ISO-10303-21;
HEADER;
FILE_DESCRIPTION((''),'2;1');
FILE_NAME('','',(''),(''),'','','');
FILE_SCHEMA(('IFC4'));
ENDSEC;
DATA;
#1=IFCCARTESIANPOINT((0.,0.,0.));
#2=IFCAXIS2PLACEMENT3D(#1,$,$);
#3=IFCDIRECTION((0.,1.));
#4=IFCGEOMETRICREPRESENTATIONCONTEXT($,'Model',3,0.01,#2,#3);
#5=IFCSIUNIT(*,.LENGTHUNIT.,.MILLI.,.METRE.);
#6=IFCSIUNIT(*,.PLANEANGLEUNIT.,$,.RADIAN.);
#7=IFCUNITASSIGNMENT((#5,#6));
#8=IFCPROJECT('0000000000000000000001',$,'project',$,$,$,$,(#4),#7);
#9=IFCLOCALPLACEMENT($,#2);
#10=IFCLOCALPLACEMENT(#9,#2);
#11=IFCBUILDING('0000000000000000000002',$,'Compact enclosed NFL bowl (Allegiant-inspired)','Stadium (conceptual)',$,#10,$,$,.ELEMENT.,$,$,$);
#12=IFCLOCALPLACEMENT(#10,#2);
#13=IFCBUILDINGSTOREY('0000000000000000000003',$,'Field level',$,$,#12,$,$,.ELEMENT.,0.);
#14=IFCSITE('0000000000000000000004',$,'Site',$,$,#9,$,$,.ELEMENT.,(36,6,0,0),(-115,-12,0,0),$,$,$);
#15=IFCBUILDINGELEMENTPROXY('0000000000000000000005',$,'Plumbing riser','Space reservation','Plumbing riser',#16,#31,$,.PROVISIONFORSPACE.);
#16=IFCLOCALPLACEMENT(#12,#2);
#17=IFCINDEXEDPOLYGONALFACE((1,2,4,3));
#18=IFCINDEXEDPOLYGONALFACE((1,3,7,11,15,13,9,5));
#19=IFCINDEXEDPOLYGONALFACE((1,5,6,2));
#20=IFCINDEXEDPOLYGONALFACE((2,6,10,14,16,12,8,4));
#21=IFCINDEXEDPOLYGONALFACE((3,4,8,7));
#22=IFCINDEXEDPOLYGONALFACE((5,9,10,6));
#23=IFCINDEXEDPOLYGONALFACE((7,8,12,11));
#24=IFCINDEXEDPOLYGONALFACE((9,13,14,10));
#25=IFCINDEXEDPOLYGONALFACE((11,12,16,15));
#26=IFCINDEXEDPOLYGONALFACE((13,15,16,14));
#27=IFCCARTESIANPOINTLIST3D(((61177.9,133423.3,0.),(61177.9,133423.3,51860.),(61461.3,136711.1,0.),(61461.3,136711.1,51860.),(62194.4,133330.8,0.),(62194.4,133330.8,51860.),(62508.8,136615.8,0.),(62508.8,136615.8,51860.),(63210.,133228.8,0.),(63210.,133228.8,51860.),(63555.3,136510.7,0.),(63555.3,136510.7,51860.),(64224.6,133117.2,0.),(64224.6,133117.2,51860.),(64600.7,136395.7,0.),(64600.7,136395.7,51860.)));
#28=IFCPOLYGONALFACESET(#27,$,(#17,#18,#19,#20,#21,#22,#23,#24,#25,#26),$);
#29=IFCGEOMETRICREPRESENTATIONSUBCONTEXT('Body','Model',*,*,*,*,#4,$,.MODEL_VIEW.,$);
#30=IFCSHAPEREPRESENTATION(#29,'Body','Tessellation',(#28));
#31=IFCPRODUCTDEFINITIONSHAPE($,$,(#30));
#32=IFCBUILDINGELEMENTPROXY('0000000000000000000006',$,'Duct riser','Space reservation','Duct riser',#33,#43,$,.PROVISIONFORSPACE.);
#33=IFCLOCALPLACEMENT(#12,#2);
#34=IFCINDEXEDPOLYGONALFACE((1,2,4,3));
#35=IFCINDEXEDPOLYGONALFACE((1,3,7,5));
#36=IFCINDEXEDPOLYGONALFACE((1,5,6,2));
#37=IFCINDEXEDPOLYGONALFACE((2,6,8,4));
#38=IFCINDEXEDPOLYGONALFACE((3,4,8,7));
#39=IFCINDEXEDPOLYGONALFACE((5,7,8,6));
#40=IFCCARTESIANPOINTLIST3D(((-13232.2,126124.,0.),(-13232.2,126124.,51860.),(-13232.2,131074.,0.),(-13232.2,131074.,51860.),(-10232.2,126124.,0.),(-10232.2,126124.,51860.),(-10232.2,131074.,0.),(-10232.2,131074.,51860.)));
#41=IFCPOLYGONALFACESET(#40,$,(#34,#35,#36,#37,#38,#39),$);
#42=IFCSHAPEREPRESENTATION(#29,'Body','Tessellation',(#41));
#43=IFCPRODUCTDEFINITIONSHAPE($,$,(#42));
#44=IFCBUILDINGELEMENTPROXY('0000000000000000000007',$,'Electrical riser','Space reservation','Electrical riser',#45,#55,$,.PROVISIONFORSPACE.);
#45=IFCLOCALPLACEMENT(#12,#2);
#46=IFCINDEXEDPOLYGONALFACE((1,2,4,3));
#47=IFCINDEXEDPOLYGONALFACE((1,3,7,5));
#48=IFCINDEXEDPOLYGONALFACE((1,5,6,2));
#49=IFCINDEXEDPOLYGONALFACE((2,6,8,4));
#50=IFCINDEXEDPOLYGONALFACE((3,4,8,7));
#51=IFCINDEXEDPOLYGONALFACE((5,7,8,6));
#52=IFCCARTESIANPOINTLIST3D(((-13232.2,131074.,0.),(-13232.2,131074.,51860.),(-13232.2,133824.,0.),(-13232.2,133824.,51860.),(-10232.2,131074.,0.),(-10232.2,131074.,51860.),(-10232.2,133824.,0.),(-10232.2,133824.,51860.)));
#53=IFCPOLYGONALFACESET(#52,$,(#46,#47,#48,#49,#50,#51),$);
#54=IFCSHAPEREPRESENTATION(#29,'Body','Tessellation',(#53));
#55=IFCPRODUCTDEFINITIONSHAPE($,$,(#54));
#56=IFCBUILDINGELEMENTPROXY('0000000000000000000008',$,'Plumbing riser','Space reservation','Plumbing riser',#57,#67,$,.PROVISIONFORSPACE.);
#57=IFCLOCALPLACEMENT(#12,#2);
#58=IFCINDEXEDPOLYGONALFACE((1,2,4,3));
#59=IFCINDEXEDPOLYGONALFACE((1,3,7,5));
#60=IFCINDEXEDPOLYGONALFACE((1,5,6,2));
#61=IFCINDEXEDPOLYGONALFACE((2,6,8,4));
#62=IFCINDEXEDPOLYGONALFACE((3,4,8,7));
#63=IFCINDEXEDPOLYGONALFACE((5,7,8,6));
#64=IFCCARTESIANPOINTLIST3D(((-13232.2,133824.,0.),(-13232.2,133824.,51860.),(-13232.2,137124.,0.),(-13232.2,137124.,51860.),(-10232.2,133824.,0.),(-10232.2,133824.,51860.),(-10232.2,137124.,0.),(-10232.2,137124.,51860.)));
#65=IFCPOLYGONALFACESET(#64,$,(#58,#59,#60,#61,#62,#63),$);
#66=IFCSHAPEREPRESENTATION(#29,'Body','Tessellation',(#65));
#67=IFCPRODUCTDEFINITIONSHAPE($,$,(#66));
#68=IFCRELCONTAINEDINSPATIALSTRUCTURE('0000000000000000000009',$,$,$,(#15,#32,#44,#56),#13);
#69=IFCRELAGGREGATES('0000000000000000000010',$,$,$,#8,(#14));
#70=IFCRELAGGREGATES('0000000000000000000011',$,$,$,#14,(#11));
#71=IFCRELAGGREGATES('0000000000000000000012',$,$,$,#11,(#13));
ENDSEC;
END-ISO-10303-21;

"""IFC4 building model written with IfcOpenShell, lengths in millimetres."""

from ifc_helpers import new_model, si_unit, direction, origin, place, context, subcontext, project, spatial, line, arc, indexed_curve, outline, extrude, element, save


model = new_model("IFC4")

# Units and contexts
model_context = context("Model", 3, precision=0.01, world=origin(), true_north=direction((0.0, 1.0)))
body_context = subcontext(model_context, "Body", "Model", "MODEL_VIEW")
ifc_project = project(units=[si_unit("LENGTHUNIT", "METRE", prefix="MILLI"), si_unit("PLANEANGLEUNIT", "RADIAN")], contexts=[model_context])

# Site, building, storey
site_placement = place(None, origin())
site = spatial("IfcSite", under=ifc_project, at=site_placement, Name="Site", CompositionType="ELEMENT", RefLatitude=(36, 6, 0, 0), RefLongitude=(-115, -12, 0, 0))
building_placement = place(site_placement, origin())
building = spatial("IfcBuilding", under=site, at=building_placement, Name="Compact enclosed NFL bowl (Allegiant-inspired)", Description="Stadium (conceptual)", CompositionType="ELEMENT")
storey_placement = place(building_placement, origin())
storey = spatial("IfcBuildingStorey", under=building, at=storey_placement, Name="Field level", CompositionType="ELEMENT", Elevation=0.0)

# Shared definitions
placement_1 = place(storey_placement, origin())

# Building element proxies
element("IfcBuildingElementProxy", 1, at=placement_1, inside=storey, Name="Plumbing riser", Description="Space reservation", ObjectType="Plumbing riser", PredefinedType="PROVISIONFORSPACE", context=body_context, shape_type="SweptSolid", body=[
    extrude(outline(indexed_curve([(64224.6, 133117.2), (62702.3, 133281.0), (61177.9, 133423.3), (61461.3, 136711.1), (63032.1, 136564.5), (64600.7, 136395.7)], segments=[arc(1, 2, 3), line(3, 4), arc(4, 5, 6), line(6, 1)], self_intersect=False)), origin(), (0.0, 0.0, 1.0), 51860.0),
])
element("IfcBuildingElementProxy", 2, at=placement_1, inside=storey, Name="Duct riser", Description="Space reservation", ObjectType="Duct riser", PredefinedType="PROVISIONFORSPACE", context=body_context, shape_type="SweptSolid", body=[
    extrude(outline(indexed_curve([(-10232.2, 126124.0), (-13232.2, 126124.0), (-13232.2, 131074.0), (-10232.2, 131074.0)], segments=[line(1, 2), line(2, 3), line(3, 4), line(4, 1)], self_intersect=False)), origin(), (0.0, 0.0, 1.0), 51860.0),
])
element("IfcBuildingElementProxy", 3, at=placement_1, inside=storey, Name="Electrical riser", Description="Space reservation", ObjectType="Electrical riser", PredefinedType="PROVISIONFORSPACE", context=body_context, shape_type="SweptSolid", body=[
    extrude(outline(indexed_curve([(-10232.2, 131074.0), (-13232.2, 131074.0), (-13232.2, 133824.0), (-10232.2, 133824.0)], segments=[line(1, 2), line(2, 3), line(3, 4), line(4, 1)], self_intersect=False)), origin(), (0.0, 0.0, 1.0), 51860.0),
])
element("IfcBuildingElementProxy", 4, at=placement_1, inside=storey, Name="Plumbing riser", Description="Space reservation", ObjectType="Plumbing riser", PredefinedType="PROVISIONFORSPACE", context=body_context, shape_type="SweptSolid", body=[
    extrude(outline(indexed_curve([(-10232.2, 133824.0), (-13232.2, 133824.0), (-13232.2, 137124.0), (-10232.2, 137124.0)], segments=[line(1, 2), line(2, 3), line(3, 4), line(4, 1)], self_intersect=False)), origin(), (0.0, 0.0, 1.0), 51860.0),
])

save(model, "model.ifc")
